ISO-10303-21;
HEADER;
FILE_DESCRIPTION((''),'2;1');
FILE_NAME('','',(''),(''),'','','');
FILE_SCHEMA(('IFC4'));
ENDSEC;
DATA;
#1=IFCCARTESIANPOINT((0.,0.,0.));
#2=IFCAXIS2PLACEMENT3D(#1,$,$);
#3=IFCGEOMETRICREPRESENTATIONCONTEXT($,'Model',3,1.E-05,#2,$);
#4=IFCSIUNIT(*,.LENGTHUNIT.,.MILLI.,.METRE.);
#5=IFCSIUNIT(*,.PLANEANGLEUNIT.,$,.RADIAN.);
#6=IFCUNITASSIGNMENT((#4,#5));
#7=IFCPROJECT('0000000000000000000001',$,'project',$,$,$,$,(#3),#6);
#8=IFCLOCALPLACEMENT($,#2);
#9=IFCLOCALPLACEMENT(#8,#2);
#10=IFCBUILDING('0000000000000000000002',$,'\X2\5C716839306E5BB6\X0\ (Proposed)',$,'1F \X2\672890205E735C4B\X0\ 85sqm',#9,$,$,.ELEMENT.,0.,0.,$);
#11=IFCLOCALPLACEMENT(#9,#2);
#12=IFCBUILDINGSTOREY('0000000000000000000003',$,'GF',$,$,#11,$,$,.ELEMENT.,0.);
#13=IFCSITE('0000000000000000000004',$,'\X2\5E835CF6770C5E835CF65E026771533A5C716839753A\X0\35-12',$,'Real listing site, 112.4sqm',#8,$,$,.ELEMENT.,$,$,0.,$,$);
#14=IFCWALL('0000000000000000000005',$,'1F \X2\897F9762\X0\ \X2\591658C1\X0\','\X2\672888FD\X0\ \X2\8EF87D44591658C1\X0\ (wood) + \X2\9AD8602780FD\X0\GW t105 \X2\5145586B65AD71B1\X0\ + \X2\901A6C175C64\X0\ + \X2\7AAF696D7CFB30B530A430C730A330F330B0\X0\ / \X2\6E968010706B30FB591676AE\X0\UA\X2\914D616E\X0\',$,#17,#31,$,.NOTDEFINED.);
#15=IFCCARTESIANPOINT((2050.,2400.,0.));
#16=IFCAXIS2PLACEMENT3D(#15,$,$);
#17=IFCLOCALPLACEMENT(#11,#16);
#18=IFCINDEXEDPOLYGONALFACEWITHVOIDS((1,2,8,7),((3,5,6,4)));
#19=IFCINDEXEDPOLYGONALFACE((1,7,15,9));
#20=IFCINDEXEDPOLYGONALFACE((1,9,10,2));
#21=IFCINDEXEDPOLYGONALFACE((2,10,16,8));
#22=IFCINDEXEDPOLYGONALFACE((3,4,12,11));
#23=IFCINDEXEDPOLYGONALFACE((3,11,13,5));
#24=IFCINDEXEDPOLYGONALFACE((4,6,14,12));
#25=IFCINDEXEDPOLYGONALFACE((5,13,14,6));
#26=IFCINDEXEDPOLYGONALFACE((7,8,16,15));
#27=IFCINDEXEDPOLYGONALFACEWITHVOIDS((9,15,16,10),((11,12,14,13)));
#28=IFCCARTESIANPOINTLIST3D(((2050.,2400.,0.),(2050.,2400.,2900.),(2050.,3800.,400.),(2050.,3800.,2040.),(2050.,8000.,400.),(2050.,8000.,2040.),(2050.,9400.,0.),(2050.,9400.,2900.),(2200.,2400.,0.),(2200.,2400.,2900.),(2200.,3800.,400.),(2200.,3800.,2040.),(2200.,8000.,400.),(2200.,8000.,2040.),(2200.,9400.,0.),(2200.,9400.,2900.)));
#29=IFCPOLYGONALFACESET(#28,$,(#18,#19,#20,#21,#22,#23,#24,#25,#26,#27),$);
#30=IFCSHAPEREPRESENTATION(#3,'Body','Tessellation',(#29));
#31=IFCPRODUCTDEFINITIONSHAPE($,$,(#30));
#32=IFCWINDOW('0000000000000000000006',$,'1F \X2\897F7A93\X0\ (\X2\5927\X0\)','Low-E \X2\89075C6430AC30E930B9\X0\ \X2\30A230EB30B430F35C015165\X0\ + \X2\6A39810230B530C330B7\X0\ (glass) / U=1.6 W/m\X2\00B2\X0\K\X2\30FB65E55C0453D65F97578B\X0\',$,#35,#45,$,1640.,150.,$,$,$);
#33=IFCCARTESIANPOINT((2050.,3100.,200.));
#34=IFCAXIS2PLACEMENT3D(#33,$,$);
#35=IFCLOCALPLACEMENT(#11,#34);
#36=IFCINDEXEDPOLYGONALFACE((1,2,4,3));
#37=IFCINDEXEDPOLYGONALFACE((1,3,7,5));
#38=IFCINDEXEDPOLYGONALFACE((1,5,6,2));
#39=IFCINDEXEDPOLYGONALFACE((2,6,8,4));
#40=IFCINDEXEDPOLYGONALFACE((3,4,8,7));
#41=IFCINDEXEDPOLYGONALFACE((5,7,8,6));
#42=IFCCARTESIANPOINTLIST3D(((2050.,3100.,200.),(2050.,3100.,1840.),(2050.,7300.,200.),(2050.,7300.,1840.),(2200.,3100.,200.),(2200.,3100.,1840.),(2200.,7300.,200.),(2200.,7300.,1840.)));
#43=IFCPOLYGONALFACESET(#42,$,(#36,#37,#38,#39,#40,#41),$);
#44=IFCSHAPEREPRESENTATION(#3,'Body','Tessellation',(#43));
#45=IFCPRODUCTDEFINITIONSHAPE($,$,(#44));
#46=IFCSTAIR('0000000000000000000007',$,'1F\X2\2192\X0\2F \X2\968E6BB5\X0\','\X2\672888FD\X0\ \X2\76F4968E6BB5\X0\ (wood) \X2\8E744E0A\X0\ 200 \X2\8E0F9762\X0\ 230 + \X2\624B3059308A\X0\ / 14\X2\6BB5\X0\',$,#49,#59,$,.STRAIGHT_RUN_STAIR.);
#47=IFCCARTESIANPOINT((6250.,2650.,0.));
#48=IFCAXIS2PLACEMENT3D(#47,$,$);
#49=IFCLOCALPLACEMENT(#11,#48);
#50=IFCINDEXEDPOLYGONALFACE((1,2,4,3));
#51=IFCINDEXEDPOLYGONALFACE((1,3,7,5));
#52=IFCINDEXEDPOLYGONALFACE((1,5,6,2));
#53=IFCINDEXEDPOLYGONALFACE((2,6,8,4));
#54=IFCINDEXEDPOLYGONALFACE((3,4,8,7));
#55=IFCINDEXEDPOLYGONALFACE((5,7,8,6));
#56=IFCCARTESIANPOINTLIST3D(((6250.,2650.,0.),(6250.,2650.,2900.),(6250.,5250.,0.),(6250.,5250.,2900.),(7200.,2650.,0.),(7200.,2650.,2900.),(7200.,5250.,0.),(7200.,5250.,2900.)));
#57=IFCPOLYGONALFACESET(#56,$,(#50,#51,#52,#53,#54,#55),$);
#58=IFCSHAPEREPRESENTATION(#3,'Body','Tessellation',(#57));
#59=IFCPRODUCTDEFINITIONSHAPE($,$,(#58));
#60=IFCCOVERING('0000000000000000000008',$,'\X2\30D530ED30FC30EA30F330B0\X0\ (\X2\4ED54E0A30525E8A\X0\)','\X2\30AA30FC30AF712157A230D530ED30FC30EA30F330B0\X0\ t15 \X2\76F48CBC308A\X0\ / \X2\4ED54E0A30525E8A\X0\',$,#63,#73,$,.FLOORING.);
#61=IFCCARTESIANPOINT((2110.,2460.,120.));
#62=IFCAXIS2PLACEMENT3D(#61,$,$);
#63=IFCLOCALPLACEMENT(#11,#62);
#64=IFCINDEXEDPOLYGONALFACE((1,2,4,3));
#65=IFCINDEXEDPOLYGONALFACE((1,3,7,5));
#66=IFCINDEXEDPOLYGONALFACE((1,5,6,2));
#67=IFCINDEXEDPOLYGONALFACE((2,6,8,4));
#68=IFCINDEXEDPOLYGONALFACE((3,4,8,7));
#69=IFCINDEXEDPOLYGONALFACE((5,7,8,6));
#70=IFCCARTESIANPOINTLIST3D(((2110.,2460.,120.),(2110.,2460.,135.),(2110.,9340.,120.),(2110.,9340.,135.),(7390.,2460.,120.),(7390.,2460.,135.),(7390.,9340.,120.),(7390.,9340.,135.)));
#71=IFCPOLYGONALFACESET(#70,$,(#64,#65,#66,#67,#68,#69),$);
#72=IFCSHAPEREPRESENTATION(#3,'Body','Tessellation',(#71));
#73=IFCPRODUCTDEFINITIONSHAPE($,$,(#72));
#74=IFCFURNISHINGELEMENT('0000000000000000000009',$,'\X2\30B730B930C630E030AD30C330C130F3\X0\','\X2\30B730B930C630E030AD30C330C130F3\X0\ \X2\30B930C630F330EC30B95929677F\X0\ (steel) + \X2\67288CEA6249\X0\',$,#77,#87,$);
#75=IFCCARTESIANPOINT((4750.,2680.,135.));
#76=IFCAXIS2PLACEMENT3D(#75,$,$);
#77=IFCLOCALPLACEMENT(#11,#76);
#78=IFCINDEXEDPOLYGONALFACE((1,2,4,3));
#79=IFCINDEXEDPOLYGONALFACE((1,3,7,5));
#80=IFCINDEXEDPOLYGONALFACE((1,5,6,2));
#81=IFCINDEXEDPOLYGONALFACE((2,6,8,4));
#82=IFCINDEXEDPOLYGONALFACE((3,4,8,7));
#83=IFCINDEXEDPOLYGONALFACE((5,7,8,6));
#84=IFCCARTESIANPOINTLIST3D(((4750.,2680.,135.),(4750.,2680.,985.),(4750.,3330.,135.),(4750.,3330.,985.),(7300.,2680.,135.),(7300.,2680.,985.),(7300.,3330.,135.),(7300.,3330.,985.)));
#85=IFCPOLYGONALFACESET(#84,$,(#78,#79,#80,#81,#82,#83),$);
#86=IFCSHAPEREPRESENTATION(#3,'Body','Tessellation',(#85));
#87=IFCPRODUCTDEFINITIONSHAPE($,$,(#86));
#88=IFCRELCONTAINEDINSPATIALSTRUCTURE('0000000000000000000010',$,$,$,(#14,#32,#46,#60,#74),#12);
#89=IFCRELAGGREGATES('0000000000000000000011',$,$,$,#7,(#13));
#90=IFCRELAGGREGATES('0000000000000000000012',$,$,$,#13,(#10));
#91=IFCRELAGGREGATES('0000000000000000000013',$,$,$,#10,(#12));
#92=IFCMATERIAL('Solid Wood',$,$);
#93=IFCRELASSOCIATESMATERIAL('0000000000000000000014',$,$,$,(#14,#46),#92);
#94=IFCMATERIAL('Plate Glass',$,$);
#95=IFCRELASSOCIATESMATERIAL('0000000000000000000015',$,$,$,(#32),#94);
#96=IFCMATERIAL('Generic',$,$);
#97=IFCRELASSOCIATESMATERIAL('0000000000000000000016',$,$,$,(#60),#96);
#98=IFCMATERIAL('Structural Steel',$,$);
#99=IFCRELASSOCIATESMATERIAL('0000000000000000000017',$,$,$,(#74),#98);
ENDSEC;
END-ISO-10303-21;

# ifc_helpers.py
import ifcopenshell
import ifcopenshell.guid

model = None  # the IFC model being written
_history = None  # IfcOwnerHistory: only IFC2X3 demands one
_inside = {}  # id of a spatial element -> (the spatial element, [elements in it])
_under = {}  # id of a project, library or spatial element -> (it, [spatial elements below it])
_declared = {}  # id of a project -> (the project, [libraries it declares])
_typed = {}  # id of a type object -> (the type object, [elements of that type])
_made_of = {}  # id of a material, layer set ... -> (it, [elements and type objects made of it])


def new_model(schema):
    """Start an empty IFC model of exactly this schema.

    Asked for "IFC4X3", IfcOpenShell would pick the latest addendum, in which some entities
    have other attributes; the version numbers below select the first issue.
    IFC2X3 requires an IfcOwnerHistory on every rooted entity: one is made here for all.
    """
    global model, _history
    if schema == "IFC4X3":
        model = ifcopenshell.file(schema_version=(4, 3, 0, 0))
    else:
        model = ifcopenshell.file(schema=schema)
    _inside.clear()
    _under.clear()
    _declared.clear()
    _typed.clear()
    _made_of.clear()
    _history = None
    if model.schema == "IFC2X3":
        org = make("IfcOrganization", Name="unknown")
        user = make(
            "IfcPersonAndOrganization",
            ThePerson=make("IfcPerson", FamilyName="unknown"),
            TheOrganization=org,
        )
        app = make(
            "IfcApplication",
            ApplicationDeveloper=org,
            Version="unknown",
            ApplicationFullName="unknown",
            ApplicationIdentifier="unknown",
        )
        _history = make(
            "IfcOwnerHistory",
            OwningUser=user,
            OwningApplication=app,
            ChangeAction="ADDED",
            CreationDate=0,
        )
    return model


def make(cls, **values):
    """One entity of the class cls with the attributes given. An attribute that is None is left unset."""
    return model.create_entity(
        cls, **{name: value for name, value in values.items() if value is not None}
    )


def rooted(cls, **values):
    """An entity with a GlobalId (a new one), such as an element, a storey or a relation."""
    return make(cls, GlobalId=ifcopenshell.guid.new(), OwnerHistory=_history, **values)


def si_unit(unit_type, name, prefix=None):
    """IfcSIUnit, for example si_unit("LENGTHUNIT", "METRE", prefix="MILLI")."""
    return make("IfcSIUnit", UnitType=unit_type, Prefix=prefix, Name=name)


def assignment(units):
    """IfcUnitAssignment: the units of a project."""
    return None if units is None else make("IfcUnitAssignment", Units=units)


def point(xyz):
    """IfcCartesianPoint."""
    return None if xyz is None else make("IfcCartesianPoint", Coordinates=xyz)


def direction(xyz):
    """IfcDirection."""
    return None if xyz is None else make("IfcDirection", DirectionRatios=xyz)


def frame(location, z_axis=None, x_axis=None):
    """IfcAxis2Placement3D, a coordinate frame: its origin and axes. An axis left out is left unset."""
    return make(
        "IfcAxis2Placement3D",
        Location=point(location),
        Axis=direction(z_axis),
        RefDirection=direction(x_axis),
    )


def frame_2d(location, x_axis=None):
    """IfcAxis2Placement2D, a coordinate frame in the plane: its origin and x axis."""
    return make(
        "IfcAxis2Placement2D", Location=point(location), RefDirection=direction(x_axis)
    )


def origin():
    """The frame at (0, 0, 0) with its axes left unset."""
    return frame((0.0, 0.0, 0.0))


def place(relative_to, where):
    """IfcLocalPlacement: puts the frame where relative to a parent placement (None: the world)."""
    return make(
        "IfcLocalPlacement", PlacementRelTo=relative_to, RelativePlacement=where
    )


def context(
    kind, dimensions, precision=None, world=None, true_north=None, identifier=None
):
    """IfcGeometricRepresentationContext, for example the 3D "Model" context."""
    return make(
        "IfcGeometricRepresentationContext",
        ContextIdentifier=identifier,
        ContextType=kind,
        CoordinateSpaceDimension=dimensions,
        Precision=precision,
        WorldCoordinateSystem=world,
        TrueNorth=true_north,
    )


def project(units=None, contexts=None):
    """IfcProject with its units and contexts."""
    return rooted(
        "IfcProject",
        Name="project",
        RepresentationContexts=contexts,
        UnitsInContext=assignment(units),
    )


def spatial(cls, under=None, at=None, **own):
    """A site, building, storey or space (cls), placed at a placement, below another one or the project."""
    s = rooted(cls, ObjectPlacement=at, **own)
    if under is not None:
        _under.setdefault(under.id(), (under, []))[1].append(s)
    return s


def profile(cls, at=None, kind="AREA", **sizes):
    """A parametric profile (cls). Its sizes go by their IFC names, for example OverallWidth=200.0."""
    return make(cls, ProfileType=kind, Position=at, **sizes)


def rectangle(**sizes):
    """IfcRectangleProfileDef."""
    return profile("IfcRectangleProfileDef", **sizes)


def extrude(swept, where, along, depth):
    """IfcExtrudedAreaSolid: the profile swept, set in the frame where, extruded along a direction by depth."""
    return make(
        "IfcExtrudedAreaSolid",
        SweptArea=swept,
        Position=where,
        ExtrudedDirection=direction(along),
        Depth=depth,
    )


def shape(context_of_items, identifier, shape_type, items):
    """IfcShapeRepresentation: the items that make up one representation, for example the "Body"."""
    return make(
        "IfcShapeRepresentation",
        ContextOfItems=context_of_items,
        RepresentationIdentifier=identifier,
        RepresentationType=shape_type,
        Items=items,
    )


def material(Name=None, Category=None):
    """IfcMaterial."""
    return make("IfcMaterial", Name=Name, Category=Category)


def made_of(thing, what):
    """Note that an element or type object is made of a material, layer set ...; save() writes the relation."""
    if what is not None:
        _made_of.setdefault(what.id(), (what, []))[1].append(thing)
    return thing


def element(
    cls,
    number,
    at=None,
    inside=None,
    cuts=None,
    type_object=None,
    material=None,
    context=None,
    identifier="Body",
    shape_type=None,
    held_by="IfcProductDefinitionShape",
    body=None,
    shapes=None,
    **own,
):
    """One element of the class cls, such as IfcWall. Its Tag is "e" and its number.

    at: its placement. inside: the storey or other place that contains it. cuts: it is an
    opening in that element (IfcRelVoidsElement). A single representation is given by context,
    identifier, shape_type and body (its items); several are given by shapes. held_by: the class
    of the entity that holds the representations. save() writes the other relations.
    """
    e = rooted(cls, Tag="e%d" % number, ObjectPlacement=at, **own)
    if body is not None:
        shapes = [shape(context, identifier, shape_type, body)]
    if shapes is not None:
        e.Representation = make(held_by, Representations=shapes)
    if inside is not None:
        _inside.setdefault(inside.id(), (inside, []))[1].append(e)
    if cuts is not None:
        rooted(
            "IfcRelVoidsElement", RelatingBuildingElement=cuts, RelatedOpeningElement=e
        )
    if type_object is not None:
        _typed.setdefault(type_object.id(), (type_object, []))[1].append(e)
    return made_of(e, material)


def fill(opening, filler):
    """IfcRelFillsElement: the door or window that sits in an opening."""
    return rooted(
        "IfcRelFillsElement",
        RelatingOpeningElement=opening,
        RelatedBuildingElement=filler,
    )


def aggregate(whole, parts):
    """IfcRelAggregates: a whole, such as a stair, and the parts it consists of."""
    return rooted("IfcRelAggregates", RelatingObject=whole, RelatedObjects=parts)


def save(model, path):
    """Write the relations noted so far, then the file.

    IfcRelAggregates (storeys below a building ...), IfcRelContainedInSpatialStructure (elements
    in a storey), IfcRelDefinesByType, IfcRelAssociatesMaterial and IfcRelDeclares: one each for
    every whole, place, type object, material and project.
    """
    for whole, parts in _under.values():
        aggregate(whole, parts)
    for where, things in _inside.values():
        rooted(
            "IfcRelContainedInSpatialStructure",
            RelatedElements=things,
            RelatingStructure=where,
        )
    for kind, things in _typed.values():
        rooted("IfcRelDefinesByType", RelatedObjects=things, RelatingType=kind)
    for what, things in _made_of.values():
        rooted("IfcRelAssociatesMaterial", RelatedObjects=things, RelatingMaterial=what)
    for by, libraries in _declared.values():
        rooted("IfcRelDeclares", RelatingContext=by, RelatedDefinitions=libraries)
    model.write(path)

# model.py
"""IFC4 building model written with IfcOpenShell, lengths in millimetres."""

from ifc_helpers import new_model, si_unit, frame, frame_2d, origin, place, context, project, spatial, rectangle, extrude, material, element, fill, save


model = new_model("IFC4")

# Units and contexts
model_context = context("Model", 3, precision=1e-05, world=origin())
ifc_project = project(units=[si_unit("LENGTHUNIT", "METRE", prefix="MILLI"), si_unit("PLANEANGLEUNIT", "RADIAN")], contexts=[model_context])

# Site, building, storey
site_placement = place(None, origin())
site = spatial("IfcSite", under=ifc_project, at=site_placement, Name="広島県広島市東区山根町35-12", ObjectType="Real listing site, 112.4sqm", CompositionType="ELEMENT", RefElevation=0.0)
building_placement = place(site_placement, origin())
building = spatial("IfcBuilding", under=site, at=building_placement, Name="山根の家 (Proposed)", ObjectType="1F 木造平屋 85sqm", CompositionType="ELEMENT", ElevationOfRefHeight=0.0, ElevationOfTerrain=0.0)
storey_placement = place(building_placement, origin())
storey = spatial("IfcBuildingStorey", under=building, at=storey_placement, Name="GF", CompositionType="ELEMENT", Elevation=0.0)

# Shared definitions
ifc_material_1 = material(Name="Solid Wood")
ifc_material_2 = material(Name="Generic")

# Shared definitions
ifc_material_3 = material(Name="Plate Glass")

# Wall, opening, window
wall_1_placement = place(storey_placement, frame((2050.0, 2400.0, 0.0)))
wall_1 = element("IfcWall", 1, at=wall_1_placement, inside=storey, material=ifc_material_1, Name="1F 西面 外壁", Description="木製 軸組外壁 (wood) + 高性能GW t105 充填断熱 + 通気層 + 窯業系サイディング / 準耐火・外皮UA配慮", PredefinedType="NOTDEFINED", context=model_context, shape_type="SweptSolid", body=[
    extrude(rectangle(XDim=150.0, YDim=7000.0, at=frame_2d((75.0, 3500.0))), frame((2050.0, 2400.0, 0.0)), (0.0, 0.0, 1.0), 2900.0),
])
opening_1_placement = place(storey_placement, frame((2050.0, 3100.0, 200.0)))
opening_1 = element("IfcOpeningElement", 2, at=opening_1_placement, cuts=wall_1, PredefinedType="NOTDEFINED", context=model_context, shape_type="SweptSolid", body=[
    extrude(rectangle(XDim=150.0, YDim=4200.0, at=frame_2d((75.0, 2100.0))), frame((2050.0, 3100.0, 200.0)), (0.0, 0.0, 1.0), 1640.0),
])
window_1_placement = place(storey_placement, frame((2050.0, 3100.0, 200.0)))
window_1 = element("IfcWindow", 3, at=window_1_placement, inside=storey, material=ifc_material_3, Name="1F 西窓 (大)", Description="Low-E 複層ガラス アルゴン封入 + 樹脂サッシ (glass) / U=1.6 W/m²K・日射取得型", OverallHeight=1640.0, OverallWidth=150.0, context=model_context, shape_type="SweptSolid", body=[
    extrude(rectangle(XDim=150.0, YDim=4200.0, at=frame_2d((75.0, 2100.0))), frame((2050.0, 3100.0, 200.0)), (0.0, 0.0, 1.0), 1640.0),
])
fill(opening_1, window_1)

# Stair
stair_placement = place(storey_placement, frame((6250.0, 2650.0, 0.0)))
element("IfcStair", 4, at=stair_placement, inside=storey, material=ifc_material_1, Name="1F→2F 階段", Description="木製 直階段 (wood) 蹴上 200 踏面 230 + 手すり / 14段", PredefinedType="STRAIGHT_RUN_STAIR", context=model_context, shape_type="SweptSolid", body=[
    extrude(rectangle(XDim=950.0, YDim=2600.0, at=frame_2d((475.0, 1300.0))), frame((6250.0, 2650.0, 0.0)), (0.0, 0.0, 1.0), 2900.0),
])

# Covering
covering_placement = place(storey_placement, frame((2110.0, 2460.0, 120.0)))
element("IfcCovering", 5, at=covering_placement, inside=storey, material=ifc_material_2, Name="フローリング (仕上げ床)", Description="オーク無垢フローリング t15 直貼り / 仕上げ床", PredefinedType="FLOORING", context=model_context, shape_type="SweptSolid", body=[
    extrude(rectangle(XDim=5280.0, YDim=6880.0, at=frame_2d((2640.0, 3440.0))), frame((2110.0, 2460.0, 120.0)), (0.0, 0.0, 1.0), 15.0),
])

# Furnishing element
ifc_material_4 = material(Name="Structural Steel")
furnishing_placement = place(storey_placement, frame((4750.0, 2680.0, 135.0)))
element("IfcFurnishingElement", 6, at=furnishing_placement, inside=storey, material=ifc_material_4, Name="システムキッチン", Description="システムキッチン ステンレス天板 (steel) + 木質扉", context=model_context, shape_type="SweptSolid", body=[
    extrude(rectangle(XDim=2550.0, YDim=650.0, at=frame_2d((1275.0, 325.0))), frame((4750.0, 2680.0, 135.0)), (0.0, 0.0, 1.0), 850.0),
])

save(model, "model.ifc")
